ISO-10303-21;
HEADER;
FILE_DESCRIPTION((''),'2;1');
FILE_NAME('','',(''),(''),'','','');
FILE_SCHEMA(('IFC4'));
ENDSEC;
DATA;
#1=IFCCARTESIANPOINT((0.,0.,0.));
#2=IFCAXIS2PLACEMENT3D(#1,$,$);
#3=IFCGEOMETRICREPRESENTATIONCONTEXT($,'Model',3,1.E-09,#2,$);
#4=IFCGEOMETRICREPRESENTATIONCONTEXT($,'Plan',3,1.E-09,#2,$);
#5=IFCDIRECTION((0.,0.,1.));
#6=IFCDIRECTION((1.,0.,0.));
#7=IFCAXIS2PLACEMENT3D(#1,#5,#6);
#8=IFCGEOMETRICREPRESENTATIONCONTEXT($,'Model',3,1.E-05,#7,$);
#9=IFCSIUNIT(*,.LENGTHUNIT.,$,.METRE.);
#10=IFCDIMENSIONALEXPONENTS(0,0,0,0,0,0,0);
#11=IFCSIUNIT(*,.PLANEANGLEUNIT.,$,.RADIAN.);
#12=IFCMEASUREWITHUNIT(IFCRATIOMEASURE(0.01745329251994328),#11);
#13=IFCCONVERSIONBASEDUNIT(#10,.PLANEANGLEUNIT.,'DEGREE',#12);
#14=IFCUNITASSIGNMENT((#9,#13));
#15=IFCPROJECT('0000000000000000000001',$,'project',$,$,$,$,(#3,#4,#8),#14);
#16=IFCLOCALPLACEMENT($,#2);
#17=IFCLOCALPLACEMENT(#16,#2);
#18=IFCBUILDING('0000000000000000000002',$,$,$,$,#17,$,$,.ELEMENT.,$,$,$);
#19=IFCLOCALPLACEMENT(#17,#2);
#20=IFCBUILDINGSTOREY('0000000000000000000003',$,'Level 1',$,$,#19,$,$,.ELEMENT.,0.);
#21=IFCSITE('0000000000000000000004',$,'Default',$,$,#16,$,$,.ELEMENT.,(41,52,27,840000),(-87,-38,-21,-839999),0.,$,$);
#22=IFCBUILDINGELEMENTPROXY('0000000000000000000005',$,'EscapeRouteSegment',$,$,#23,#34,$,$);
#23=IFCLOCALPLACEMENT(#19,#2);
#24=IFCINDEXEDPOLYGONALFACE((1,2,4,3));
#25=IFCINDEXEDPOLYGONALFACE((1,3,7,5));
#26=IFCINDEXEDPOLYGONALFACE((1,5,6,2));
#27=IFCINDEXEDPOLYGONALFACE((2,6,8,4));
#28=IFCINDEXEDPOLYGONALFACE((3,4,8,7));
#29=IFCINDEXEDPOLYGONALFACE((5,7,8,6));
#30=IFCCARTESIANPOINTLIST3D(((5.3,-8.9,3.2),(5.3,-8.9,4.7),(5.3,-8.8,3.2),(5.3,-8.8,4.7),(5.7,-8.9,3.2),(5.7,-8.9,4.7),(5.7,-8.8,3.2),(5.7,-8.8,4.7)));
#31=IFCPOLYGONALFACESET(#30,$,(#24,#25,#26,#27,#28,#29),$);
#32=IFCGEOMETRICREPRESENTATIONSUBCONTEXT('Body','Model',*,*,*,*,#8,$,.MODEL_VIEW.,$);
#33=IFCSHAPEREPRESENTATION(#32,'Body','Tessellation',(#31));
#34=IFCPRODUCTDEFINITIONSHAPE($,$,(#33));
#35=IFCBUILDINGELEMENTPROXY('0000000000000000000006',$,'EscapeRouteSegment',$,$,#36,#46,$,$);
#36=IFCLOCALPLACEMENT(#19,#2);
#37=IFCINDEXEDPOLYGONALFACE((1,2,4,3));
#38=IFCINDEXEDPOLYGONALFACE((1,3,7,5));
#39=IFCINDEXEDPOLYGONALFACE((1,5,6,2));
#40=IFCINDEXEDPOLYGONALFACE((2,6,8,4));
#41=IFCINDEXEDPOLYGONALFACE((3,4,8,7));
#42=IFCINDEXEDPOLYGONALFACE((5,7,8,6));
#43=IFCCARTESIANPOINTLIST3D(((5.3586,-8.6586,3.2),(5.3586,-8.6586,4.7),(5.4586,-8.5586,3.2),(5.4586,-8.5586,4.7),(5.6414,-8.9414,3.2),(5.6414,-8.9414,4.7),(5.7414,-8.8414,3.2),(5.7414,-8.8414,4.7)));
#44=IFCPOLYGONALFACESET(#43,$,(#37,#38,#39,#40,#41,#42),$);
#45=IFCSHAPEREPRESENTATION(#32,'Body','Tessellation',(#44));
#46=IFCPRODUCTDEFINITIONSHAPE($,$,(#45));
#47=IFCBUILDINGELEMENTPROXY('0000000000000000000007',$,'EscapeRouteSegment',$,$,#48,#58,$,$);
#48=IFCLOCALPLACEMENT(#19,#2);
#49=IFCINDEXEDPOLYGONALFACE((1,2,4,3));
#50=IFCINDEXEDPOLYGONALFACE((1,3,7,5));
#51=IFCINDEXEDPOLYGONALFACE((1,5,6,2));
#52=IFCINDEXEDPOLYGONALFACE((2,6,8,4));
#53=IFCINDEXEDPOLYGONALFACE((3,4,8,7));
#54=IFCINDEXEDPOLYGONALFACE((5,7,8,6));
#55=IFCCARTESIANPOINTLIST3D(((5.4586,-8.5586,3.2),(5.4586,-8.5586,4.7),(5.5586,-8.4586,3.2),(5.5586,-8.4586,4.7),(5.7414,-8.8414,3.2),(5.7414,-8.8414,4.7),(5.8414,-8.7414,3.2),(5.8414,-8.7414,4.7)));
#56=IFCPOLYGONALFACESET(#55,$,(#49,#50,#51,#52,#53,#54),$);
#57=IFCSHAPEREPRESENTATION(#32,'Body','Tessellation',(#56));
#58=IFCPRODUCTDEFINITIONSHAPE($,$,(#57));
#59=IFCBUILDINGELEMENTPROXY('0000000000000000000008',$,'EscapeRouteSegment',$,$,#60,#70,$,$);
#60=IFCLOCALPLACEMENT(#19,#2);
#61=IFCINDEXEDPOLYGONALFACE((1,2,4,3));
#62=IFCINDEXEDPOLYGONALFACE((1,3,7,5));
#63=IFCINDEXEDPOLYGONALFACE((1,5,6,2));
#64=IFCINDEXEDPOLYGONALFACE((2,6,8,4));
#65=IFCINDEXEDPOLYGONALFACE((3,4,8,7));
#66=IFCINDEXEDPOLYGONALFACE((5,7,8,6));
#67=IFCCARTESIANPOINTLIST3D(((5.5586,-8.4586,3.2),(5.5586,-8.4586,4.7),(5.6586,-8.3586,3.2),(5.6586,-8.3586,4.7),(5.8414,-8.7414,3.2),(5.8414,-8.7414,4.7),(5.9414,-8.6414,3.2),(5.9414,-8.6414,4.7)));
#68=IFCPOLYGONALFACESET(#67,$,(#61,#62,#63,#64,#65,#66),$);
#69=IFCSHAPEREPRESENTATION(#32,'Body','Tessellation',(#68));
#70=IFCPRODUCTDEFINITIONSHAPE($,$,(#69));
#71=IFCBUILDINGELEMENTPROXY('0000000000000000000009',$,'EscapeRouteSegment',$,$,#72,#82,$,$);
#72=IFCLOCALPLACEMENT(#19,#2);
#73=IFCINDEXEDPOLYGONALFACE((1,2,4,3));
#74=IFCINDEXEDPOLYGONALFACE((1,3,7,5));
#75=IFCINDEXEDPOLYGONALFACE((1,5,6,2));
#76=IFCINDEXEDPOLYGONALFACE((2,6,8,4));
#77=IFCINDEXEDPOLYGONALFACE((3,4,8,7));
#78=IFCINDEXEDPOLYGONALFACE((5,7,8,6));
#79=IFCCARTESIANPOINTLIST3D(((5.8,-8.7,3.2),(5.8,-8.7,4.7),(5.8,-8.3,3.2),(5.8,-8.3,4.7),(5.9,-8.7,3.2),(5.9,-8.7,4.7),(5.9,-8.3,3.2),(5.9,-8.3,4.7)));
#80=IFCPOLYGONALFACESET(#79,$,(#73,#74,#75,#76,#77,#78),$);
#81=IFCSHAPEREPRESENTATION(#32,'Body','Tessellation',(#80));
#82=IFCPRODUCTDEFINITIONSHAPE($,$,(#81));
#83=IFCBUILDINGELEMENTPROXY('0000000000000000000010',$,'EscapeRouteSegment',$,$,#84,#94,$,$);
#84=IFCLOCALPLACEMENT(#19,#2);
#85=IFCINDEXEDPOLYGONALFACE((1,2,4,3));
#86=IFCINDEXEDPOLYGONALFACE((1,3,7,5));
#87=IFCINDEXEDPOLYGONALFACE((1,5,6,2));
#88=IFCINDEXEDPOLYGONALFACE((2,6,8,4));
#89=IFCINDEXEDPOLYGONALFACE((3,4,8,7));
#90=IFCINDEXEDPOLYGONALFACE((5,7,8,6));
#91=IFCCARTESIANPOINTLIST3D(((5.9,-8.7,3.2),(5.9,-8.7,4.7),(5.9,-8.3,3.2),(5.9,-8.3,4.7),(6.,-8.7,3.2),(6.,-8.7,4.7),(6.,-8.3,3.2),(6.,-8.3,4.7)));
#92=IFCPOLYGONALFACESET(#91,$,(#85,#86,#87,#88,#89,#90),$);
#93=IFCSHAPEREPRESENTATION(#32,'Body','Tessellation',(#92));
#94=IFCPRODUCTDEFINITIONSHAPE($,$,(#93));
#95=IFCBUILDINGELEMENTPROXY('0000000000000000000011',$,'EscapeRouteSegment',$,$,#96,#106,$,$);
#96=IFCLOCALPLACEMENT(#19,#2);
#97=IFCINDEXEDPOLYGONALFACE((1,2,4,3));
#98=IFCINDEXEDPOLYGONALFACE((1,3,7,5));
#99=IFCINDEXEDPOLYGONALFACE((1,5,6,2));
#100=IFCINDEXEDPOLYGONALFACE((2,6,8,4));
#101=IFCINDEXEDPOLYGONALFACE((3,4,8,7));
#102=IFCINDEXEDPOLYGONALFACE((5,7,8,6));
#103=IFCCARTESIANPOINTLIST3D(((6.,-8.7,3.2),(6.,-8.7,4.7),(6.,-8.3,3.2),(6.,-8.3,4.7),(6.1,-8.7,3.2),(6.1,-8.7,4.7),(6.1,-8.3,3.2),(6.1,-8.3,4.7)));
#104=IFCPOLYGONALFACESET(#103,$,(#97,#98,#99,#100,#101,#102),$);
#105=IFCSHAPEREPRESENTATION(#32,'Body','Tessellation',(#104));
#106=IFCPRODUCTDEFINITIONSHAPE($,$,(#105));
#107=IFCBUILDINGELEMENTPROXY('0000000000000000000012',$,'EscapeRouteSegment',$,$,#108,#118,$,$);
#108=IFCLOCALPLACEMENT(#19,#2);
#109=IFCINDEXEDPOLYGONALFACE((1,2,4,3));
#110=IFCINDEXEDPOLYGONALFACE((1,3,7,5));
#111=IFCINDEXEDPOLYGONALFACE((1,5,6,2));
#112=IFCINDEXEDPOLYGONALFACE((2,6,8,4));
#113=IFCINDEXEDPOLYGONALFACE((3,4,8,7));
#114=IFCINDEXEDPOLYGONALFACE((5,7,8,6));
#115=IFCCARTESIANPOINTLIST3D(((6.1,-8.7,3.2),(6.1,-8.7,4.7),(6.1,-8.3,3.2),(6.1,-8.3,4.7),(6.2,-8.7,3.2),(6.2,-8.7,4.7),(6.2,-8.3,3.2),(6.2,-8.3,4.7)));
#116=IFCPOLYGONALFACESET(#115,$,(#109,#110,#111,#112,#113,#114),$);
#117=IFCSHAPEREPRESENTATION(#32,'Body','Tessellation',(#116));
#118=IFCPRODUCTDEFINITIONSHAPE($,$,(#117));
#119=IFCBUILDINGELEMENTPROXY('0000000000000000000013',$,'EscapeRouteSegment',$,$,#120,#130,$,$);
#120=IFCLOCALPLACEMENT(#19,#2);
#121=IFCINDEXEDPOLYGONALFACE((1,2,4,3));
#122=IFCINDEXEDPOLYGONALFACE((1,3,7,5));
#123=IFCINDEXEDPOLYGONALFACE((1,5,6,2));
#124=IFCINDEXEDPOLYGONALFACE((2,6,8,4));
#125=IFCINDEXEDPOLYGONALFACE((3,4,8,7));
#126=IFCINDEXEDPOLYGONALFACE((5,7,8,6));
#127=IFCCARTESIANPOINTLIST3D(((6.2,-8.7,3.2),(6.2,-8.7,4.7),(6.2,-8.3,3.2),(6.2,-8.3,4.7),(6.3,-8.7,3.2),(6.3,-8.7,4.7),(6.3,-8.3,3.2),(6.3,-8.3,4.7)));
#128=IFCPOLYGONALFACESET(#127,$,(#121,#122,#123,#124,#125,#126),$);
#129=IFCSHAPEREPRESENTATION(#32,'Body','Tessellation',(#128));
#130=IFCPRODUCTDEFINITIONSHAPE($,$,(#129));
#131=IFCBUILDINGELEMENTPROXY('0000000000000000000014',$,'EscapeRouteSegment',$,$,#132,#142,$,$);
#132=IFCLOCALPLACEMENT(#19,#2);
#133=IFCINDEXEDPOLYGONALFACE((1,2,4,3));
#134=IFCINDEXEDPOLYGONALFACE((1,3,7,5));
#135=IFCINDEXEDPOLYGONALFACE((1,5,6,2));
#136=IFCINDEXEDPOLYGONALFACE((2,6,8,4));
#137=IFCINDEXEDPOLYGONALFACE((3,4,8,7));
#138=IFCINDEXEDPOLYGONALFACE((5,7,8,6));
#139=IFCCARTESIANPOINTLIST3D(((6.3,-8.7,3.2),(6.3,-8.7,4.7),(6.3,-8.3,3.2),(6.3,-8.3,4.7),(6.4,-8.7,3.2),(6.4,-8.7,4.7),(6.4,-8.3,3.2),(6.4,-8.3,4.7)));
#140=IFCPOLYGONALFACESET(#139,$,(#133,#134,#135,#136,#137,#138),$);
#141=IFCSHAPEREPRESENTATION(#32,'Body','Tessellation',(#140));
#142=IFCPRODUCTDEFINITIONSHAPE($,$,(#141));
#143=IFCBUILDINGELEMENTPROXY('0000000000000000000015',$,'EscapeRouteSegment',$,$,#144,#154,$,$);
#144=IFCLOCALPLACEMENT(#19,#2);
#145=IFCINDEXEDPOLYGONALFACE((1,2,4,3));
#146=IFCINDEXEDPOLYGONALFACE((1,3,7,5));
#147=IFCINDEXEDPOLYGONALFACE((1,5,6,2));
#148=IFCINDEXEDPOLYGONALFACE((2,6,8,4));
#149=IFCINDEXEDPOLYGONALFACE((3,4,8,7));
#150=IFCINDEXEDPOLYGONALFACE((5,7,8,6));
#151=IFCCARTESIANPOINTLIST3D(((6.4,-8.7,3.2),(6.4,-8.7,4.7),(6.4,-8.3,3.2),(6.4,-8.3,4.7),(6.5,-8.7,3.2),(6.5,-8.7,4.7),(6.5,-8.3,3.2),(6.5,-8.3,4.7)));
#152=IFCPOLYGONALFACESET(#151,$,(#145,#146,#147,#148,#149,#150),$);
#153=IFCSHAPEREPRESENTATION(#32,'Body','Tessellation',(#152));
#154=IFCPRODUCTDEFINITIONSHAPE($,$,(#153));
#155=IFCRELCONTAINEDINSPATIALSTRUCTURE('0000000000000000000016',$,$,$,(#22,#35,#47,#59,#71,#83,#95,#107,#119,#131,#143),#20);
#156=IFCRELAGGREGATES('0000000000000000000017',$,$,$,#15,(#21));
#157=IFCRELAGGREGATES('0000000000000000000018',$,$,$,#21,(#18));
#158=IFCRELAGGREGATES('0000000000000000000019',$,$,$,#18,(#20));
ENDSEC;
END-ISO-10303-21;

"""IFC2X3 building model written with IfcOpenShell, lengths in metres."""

from ifc_helpers import new_model, entity, si_unit, converted_unit, frame, origin, origin_with_axes, place, context, subcontext, project, spatial, polyline, outline, extrude, element, save


model = new_model("IFC2X3")

# Units and contexts
model_context_1 = context("Model", 3, precision=1e-09, world=origin())
plan_context = context("Plan", 3, precision=1e-09, world=origin())
model_context_2 = context("Model", 3, precision=1e-05, world=origin_with_axes())
body_context = subcontext(model_context_2, "Body", "Model", "MODEL_VIEW")
ifc_project = project(units=[si_unit("LENGTHUNIT", "METRE"), converted_unit("PLANEANGLEUNIT", "DEGREE", entity("IfcRatioMeasure", 0.01745329251994328), si_unit("PLANEANGLEUNIT", "RADIAN"), dimensions=[0, 0, 0, 0, 0, 0, 0])], contexts=[model_context_1, plan_context, model_context_2])

# Site, building, storey
site_placement = place(None, origin())
site = spatial("IfcSite", under=ifc_project, at=site_placement, Name="Default", CompositionType="ELEMENT", RefLatitude=(41, 52, 27, 840000), RefLongitude=(-87, -38, -21, -839999), RefElevation=0.0)
building_placement = place(site_placement, origin())
building = spatial("IfcBuilding", under=site, at=building_placement, CompositionType="ELEMENT")
storey_placement = place(building_placement, origin())
storey = spatial("IfcBuildingStorey", under=building, at=storey_placement, Name="Level 1", CompositionType="ELEMENT", Elevation=0.0)

# Building element proxies
proxy_1_placement = place(storey_placement, frame((5.5, -8.9, 3.2), z_axis=(0.0, 0.0, 1.0), x_axis=(0.0, 1.0, 0.0)))
element("IfcBuildingElementProxy", 1, at=proxy_1_placement, inside=storey, Name="EscapeRouteSegment", context=body_context, shape_type="SweptSolid", body=[
    extrude(outline(polyline([(0.0, -0.2), (0.0, 0.2), (0.1, 0.2), (0.1, -0.2), (0.0, -0.2)])), origin_with_axes(), (0.0, 0.0, 1.0), 1.5),
])
proxy_2_placement = place(storey_placement, frame((5.5, -8.8, 3.2), z_axis=(0.0, 0.0, 1.0), x_axis=(0.707105, 0.707108, 0.0)))
element("IfcBuildingElementProxy", 2, at=proxy_2_placement, inside=storey, Name="EscapeRouteSegment", context=body_context, shape_type="SweptSolid", body=[
    extrude(outline(polyline([(0.0, -0.2), (0.0, 0.2), (0.1414, 0.2), (0.1414, -0.2), (0.0, -0.2)])), origin_with_axes(), (0.0, 0.0, 1.0), 1.5),
])
proxy_3_placement = place(storey_placement, frame((5.6, -8.7, 3.2), z_axis=(0.0, 0.0, 1.0), x_axis=(0.707108, 0.707105, 0.0)))
element("IfcBuildingElementProxy", 3, at=proxy_3_placement, inside=storey, Name="EscapeRouteSegment", context=body_context, shape_type="SweptSolid", body=[
    extrude(outline(polyline([(0.0, -0.2), (0.0, 0.2), (0.1414, 0.2), (0.1414, -0.2), (0.0, -0.2)])), origin_with_axes(), (0.0, 0.0, 1.0), 1.5),
])
proxy_4_placement = place(storey_placement, frame((5.7, -8.6, 3.2), z_axis=(0.0, 0.0, 1.0), x_axis=(0.707107, 0.707107, 0.0)))
element("IfcBuildingElementProxy", 4, at=proxy_4_placement, inside=storey, Name="EscapeRouteSegment", context=body_context, shape_type="SweptSolid", body=[
    extrude(outline(polyline([(0.0, -0.2), (0.0, 0.2), (0.1414, 0.2), (0.1414, -0.2), (0.0, -0.2)])), origin_with_axes(), (0.0, 0.0, 1.0), 1.5),
])
for number, where, z_axis, x_axis, name in (
    (5, (5.8, -8.5, 3.2), (0.0, 0.0, 1.0), (1.0, 0.0, 0.0), "EscapeRouteSegment"),
    (6, (5.9, -8.5, 3.2), (0.0, 0.0, 1.0), (1.0, 0.0, 0.0), "EscapeRouteSegment"),
    (7, (6.0, -8.5, 3.2), (0.0, 0.0, 1.0), (1.0, 0.0, 0.0), "EscapeRouteSegment"),
    (8, (6.1, -8.5, 3.2), (0.0, 0.0, 1.0), (1.0, 0.0, 0.0), "EscapeRouteSegment"),
):
    element("IfcBuildingElementProxy", number, at=place(storey_placement, frame(where, z_axis=z_axis, x_axis=x_axis)), inside=storey, Name=name, context=body_context, shape_type="SweptSolid", body=[
        extrude(outline(polyline([(0.0, -0.2), (0.0, 0.2), (0.1, 0.2), (0.1, -0.2), (0.0, -0.2)])), origin_with_axes(), (0.0, 0.0, 1.0), 1.5),
    ])
proxy_5_placement = place(storey_placement, frame((6.2, -8.5, 3.2), z_axis=(0.0, 0.0, 1.0), x_axis=(1.0, 0.0, 0.0)))
element("IfcBuildingElementProxy", 9, at=proxy_5_placement, inside=storey, Name="EscapeRouteSegment", context=body_context, shape_type="SweptSolid", body=[
    extrude(outline(polyline([(0.0, -0.2), (0.0, 0.2), (0.1, 0.2), (0.1, -0.2), (0.0, -0.2)])), origin_with_axes(), (0.0, 0.0, 1.0), 1.5),
])
for number, where, z_axis, x_axis, name in (
    (10, (6.3, -8.5, 3.2), (0.0, 0.0, 1.0), (1.0, 0.0, 0.0), "EscapeRouteSegment"),
    (11, (6.4, -8.5, 3.2), (0.0, 0.0, 1.0), (1.0, 0.0, 0.0), "EscapeRouteSegment"),
):
    element("IfcBuildingElementProxy", number, at=place(storey_placement, frame(where, z_axis=z_axis, x_axis=x_axis)), inside=storey, Name=name, context=body_context, shape_type="SweptSolid", body=[
        extrude(outline(polyline([(0.0, -0.2), (0.0, 0.2), (0.1, 0.2), (0.1, -0.2), (0.0, -0.2)])), origin_with_axes(), (0.0, 0.0, 1.0), 1.5),
    ])

save(model, "model.ifc")
